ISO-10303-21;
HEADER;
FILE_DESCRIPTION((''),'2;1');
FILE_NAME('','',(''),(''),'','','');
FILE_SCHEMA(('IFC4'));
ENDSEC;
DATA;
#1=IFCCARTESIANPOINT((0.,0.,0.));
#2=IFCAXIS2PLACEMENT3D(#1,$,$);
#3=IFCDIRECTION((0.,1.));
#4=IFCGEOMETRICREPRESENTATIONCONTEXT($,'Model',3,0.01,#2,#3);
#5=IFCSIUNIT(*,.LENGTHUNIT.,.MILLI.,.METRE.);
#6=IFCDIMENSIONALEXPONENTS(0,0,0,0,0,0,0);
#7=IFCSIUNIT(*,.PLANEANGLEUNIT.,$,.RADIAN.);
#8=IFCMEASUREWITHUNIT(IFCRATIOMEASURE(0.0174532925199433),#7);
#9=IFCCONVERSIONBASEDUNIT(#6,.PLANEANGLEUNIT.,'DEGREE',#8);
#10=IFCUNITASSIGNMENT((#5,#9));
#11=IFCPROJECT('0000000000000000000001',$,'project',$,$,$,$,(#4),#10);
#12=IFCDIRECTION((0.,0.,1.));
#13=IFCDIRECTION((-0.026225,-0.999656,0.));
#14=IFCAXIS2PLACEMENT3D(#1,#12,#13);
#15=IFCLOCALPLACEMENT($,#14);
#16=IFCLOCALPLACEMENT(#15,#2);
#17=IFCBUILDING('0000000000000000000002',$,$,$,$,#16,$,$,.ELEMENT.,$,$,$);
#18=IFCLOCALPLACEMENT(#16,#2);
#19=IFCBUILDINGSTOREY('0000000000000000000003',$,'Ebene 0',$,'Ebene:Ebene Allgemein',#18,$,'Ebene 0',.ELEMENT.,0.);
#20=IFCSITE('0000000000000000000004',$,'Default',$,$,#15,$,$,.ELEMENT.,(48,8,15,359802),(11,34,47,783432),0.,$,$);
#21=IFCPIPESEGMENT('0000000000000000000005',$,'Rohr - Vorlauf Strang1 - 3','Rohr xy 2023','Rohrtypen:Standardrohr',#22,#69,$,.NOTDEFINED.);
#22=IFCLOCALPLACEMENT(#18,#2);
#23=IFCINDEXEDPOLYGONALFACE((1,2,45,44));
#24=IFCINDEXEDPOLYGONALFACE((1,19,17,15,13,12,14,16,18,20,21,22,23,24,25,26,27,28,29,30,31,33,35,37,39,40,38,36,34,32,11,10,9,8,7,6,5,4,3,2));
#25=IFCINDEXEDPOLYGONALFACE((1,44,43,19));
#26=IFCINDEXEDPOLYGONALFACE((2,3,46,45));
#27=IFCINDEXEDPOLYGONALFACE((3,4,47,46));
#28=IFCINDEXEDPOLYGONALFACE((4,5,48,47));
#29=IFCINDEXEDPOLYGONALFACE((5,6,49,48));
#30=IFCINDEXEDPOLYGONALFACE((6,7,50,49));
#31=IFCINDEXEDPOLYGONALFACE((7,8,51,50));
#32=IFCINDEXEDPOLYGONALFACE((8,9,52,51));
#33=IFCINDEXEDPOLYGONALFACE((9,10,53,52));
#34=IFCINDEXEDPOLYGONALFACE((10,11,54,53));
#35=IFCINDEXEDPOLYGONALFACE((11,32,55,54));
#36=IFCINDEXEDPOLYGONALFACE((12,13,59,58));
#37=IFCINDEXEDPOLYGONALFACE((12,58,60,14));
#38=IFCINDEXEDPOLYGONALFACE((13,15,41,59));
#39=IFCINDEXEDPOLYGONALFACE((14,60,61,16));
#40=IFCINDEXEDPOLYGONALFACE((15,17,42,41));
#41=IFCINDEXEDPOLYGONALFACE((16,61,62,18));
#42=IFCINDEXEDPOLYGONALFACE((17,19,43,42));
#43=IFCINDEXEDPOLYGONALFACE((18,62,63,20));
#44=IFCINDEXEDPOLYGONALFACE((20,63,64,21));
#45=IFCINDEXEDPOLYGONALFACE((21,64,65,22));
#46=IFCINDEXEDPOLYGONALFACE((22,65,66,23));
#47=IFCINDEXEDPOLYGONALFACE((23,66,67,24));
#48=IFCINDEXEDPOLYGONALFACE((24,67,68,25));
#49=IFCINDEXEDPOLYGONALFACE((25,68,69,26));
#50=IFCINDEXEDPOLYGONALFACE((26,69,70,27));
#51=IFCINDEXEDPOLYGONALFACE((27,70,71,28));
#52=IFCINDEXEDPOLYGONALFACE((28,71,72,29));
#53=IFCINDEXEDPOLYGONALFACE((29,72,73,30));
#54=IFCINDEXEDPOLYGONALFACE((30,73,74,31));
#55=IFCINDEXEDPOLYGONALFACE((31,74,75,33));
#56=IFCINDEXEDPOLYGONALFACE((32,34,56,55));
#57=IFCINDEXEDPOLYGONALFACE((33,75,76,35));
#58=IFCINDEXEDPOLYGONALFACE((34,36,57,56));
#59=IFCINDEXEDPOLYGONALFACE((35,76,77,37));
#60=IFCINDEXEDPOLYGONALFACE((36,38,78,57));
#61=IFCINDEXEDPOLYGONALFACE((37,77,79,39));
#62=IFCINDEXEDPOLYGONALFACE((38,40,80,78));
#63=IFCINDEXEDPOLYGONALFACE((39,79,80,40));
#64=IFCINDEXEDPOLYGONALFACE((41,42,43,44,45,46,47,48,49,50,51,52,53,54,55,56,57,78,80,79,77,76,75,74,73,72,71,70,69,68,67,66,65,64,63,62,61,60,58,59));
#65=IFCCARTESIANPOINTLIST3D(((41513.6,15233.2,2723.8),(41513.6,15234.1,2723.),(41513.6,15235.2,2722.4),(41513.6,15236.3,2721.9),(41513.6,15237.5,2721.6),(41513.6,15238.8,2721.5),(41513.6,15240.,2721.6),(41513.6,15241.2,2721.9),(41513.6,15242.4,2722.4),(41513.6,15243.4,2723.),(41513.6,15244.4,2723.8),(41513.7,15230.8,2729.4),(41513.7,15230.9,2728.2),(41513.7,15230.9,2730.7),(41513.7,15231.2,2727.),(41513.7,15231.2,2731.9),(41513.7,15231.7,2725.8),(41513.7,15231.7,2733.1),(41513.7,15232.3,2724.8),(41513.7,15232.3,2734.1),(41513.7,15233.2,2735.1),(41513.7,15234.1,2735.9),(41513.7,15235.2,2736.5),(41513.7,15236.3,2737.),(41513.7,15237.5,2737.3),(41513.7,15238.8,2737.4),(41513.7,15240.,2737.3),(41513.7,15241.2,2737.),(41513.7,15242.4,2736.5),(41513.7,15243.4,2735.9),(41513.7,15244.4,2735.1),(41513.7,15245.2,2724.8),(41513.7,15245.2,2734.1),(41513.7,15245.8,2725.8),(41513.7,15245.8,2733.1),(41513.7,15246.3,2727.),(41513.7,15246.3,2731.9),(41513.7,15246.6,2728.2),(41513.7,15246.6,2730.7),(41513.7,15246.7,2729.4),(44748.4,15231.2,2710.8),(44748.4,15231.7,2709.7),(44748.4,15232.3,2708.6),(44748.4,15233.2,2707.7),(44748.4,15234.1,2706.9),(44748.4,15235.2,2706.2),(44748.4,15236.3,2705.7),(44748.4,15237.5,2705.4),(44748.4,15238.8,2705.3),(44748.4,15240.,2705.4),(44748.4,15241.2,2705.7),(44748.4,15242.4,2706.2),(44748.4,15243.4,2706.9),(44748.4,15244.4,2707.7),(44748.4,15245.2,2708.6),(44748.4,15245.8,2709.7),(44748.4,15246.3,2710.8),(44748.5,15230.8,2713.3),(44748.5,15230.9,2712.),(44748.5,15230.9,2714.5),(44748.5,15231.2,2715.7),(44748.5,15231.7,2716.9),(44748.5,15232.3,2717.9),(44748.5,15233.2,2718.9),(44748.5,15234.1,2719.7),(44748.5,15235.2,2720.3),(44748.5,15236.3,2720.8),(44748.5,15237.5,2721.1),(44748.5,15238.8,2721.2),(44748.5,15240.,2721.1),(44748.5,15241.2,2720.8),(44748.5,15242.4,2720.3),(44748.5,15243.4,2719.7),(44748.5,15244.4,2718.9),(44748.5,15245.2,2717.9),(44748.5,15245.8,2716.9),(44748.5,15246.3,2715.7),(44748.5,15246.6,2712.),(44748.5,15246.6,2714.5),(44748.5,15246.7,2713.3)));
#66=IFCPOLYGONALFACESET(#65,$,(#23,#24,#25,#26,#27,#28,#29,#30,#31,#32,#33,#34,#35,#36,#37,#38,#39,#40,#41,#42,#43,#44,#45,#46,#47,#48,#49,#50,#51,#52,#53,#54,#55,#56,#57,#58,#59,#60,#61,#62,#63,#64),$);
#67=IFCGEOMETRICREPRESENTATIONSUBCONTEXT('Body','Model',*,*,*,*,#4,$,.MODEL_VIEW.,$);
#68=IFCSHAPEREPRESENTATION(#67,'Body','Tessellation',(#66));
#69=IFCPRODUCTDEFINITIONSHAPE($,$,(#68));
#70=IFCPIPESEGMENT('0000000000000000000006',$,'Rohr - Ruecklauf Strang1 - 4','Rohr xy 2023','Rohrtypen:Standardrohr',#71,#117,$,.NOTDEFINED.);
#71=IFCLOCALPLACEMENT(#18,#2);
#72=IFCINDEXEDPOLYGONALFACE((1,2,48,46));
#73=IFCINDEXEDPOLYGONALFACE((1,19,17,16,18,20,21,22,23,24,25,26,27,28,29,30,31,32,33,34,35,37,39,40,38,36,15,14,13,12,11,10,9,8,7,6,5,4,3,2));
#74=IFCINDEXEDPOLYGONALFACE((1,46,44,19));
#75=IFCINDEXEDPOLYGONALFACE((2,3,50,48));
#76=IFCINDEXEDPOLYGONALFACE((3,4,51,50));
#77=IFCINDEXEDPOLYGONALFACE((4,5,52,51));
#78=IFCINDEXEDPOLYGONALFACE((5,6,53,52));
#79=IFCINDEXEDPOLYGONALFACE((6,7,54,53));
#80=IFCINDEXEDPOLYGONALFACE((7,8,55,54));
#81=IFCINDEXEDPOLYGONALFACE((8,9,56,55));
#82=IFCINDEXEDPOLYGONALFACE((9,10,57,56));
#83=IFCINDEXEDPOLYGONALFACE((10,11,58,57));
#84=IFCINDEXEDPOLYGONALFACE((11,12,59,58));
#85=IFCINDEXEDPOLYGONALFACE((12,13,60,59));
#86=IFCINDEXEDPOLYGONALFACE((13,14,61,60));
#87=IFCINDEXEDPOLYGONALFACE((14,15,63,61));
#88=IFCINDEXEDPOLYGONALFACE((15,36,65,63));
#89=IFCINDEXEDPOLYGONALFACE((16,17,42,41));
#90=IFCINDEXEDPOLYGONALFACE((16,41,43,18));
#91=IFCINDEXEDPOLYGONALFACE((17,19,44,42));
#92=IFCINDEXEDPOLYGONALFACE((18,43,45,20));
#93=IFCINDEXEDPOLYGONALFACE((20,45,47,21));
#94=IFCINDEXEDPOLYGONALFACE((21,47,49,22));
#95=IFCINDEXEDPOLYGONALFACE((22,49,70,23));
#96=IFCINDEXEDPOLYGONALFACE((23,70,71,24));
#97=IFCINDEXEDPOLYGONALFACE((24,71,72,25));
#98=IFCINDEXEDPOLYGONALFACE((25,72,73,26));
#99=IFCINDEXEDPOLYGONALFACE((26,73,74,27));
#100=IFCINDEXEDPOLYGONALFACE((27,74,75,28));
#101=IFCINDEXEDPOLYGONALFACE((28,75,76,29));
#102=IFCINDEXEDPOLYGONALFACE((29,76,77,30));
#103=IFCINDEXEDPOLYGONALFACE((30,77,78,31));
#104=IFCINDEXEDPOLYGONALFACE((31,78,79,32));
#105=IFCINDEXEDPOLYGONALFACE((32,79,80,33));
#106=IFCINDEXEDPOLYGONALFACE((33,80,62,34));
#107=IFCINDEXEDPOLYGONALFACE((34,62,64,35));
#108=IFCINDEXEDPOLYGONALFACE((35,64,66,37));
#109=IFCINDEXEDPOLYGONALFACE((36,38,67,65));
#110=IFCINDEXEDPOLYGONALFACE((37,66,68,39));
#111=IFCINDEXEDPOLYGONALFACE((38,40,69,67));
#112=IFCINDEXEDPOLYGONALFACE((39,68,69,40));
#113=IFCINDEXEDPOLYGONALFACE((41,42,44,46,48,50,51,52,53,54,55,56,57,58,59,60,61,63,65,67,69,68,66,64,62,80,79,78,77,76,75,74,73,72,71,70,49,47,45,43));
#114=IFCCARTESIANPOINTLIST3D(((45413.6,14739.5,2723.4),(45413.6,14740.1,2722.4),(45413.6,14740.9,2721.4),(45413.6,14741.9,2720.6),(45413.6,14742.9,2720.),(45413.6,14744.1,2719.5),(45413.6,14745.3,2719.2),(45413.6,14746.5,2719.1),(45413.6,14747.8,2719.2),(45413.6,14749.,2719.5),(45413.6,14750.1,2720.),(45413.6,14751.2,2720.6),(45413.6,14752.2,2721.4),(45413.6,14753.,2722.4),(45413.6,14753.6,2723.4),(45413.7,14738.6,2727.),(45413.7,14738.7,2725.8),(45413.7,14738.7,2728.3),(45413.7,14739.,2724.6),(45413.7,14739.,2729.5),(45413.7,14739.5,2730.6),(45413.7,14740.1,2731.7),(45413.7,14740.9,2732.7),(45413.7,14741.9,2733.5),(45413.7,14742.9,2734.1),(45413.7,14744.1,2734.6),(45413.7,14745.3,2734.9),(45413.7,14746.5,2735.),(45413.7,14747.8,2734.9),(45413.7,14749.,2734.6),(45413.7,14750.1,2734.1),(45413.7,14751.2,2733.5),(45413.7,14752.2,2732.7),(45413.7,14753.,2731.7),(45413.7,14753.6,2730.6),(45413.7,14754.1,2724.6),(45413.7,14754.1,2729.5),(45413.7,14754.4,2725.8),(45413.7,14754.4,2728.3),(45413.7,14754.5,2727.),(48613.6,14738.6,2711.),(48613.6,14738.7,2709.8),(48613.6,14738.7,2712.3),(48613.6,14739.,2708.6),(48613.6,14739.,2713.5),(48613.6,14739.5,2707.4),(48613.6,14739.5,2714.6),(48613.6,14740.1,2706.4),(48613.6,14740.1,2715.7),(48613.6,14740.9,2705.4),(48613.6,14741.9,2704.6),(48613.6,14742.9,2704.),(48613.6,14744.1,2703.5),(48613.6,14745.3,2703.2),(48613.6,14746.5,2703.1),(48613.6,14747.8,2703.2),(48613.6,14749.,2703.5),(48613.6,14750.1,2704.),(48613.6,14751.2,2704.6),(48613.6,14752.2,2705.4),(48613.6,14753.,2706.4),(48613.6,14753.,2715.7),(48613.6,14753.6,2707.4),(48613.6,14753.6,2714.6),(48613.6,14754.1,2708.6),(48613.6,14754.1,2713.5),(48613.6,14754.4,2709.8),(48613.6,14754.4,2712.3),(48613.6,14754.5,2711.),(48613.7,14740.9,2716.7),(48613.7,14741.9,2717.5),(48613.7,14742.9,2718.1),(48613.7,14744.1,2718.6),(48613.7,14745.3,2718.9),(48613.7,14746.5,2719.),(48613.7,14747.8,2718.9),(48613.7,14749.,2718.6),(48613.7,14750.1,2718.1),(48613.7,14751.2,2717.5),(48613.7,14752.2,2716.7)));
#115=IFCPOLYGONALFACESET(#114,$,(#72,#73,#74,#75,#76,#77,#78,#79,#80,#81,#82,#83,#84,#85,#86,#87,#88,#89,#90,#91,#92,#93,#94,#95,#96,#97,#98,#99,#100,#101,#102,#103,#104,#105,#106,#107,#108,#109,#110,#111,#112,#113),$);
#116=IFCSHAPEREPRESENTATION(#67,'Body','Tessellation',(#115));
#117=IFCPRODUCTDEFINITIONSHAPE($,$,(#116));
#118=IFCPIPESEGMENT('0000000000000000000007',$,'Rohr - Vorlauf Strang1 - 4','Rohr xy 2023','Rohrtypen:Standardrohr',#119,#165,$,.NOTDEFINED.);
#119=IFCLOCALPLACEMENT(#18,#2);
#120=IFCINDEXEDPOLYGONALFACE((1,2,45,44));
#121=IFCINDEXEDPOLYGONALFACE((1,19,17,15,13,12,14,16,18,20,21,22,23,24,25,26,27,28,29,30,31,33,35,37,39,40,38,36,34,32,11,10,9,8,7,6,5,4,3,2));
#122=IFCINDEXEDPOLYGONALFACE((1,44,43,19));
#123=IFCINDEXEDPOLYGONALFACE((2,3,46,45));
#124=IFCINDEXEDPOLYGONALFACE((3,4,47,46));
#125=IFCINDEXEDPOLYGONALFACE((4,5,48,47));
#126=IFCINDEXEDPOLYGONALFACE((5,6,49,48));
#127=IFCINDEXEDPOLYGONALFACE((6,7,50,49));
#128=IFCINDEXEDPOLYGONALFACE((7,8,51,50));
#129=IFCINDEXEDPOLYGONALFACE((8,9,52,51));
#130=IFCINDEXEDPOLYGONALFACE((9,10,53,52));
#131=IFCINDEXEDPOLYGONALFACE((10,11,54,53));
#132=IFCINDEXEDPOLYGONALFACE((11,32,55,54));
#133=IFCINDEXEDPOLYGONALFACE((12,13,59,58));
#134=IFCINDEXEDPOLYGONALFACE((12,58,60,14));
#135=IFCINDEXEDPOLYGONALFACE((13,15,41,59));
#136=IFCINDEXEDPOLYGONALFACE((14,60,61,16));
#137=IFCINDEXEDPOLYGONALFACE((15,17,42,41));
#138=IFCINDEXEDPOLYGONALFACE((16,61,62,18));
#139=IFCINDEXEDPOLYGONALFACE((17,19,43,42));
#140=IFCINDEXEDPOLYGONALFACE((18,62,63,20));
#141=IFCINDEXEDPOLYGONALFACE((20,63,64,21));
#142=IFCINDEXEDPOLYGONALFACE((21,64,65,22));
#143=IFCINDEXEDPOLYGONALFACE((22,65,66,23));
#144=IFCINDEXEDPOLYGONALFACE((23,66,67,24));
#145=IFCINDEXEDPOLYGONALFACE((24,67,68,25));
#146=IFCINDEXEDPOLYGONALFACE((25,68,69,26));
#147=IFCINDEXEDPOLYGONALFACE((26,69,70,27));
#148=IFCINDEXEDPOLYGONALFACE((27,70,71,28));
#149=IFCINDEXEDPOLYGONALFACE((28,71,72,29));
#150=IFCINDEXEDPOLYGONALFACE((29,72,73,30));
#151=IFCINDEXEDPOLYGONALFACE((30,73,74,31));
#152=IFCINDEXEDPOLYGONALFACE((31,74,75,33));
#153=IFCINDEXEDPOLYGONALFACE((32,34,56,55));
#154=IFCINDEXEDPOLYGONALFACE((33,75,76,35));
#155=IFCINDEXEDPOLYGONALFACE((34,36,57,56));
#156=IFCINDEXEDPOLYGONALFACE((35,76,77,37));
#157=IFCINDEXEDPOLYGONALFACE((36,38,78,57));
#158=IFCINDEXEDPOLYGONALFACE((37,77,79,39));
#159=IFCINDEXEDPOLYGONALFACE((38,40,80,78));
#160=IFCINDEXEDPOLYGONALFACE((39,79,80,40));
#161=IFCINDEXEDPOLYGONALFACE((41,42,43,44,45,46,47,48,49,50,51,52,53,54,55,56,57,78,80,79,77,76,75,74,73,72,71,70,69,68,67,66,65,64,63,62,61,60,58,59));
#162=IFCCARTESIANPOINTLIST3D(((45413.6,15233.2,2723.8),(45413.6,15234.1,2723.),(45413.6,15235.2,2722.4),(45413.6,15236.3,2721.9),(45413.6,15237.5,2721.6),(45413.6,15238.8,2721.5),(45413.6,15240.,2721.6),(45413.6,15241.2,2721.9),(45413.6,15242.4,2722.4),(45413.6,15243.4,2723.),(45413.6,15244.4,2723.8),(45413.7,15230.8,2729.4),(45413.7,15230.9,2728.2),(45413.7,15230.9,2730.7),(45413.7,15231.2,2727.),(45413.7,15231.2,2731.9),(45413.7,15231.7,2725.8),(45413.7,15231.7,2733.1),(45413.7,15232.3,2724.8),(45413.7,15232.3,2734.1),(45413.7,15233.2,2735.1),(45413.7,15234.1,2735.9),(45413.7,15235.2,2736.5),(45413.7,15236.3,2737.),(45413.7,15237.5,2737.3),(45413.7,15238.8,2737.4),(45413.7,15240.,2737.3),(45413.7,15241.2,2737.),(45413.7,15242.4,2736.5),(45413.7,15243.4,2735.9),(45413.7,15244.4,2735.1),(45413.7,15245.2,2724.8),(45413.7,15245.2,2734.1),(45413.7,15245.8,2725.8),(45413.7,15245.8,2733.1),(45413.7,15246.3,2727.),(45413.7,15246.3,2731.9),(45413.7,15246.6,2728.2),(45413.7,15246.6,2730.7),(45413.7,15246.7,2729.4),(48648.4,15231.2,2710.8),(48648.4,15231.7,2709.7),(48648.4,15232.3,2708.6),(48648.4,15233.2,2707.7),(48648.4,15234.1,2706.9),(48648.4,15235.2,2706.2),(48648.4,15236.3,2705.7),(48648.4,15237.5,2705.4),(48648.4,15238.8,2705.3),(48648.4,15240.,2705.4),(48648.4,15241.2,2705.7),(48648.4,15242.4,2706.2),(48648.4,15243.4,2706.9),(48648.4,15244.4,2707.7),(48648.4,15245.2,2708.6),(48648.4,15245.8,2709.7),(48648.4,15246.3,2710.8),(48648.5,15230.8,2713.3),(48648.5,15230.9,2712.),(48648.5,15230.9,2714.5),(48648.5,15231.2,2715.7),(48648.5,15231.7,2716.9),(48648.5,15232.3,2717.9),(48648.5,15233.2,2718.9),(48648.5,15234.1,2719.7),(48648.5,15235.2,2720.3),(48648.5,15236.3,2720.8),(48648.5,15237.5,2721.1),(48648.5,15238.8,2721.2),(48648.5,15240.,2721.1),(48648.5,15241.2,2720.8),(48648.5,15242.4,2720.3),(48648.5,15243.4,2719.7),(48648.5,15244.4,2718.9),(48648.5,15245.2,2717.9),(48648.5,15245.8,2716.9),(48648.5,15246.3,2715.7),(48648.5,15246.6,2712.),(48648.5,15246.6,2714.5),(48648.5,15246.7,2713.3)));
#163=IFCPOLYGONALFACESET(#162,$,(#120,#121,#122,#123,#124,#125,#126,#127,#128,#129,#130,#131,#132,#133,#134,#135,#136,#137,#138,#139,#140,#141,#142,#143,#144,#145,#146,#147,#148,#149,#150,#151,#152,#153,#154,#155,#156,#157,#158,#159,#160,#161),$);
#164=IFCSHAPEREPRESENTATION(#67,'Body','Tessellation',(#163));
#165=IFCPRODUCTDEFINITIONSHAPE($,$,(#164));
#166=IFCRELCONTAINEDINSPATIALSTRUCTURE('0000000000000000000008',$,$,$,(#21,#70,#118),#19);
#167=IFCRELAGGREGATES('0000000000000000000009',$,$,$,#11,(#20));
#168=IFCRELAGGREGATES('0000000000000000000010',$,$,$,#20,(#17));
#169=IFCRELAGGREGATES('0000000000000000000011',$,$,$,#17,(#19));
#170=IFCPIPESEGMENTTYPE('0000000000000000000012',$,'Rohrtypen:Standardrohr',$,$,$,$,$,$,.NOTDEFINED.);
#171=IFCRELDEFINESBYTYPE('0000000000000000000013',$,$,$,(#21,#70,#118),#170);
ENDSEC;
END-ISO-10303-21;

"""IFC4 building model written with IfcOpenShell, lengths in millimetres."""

from ifc_helpers import new_model, entity, si_unit, converted_unit, direction, frame, origin, place, context, subcontext, project, spatial, indexed_curve, outline, extrude, type_object, element, save


model = new_model("IFC4")

# Units and contexts
model_context = context("Model", 3, precision=0.01, world=origin(), true_north=direction((0.0, 1.0)))
body_context = subcontext(model_context, "Body", "Model", "MODEL_VIEW")
ifc_project = project(units=[si_unit("LENGTHUNIT", "METRE", prefix="MILLI"), converted_unit("PLANEANGLEUNIT", "DEGREE", entity("IfcRatioMeasure", 0.0174532925199433), si_unit("PLANEANGLEUNIT", "RADIAN"), dimensions=[0, 0, 0, 0, 0, 0, 0])], contexts=[model_context])

# Site, building, storey
site_placement = place(None, frame((0.0, 0.0, 0.0), z_axis=(0.0, 0.0, 1.0), x_axis=(-0.026225, -0.999656, 0.0)))
site = spatial("IfcSite", under=ifc_project, at=site_placement, Name="Default", CompositionType="ELEMENT", RefLatitude=(48, 8, 15, 359802), RefLongitude=(11, 34, 47, 783432), RefElevation=0.0)
building_placement = place(site_placement, origin())
building = spatial("IfcBuilding", under=site, at=building_placement, CompositionType="ELEMENT")
storey_placement = place(building_placement, origin())
storey = spatial("IfcBuildingStorey", under=building, at=storey_placement, Name="Ebene 0", ObjectType="Ebene:Ebene Allgemein", LongName="Ebene 0", CompositionType="ELEMENT", Elevation=0.0)

# Pipe segments
pipe_segment_type = type_object("IfcPipeSegmentType", Name="Rohrtypen:Standardrohr", PredefinedType="NOTDEFINED")
pipe_segment_1_placement = place(storey_placement, origin())
element("IfcPipeSegment", 1, at=pipe_segment_1_placement, inside=storey, type_object=pipe_segment_type, Name="Rohr - Vorlauf Strang1 - 3", Description="Rohr xy 2023", ObjectType="Rohrtypen:Standardrohr", PredefinedType="NOTDEFINED", context=body_context, shape_type="SweptSolid", body=[
    extrude(outline(indexed_curve([(7.9, 0.0), (7.8, 1.2), (7.6, 2.5), (7.1, 3.6), (6.4, 4.7), (5.6, 5.6), (4.7, 6.4), (3.6, 7.1), (2.5, 7.6), (1.2, 7.8), (0.0, 7.9), (-1.2, 7.8), (-2.5, 7.6), (-3.6, 7.1), (-4.7, 6.4), (-5.6, 5.6), (-6.4, 4.7), (-7.1, 3.6), (-7.6, 2.5), (-7.8, 1.2), (-7.9, 0.0), (-7.8, -1.2), (-7.6, -2.5), (-7.1, -3.6), (-6.4, -4.7), (-5.6, -5.6), (-4.7, -6.4), (-3.6, -7.1), (-2.5, -7.6), (-1.2, -7.8), (0.0, -7.9), (1.2, -7.8), (2.5, -7.6), (3.6, -7.1), (4.7, -6.4), (5.6, -5.6), (6.4, -4.7), (7.1, -3.6), (7.6, -2.5), (7.8, -1.2), (7.9, 0.0)], self_intersect=False)), frame((44748.5, 15238.8, 2713.3), z_axis=(-0.999988, 0.0, 0.005), x_axis=(0.0, 1.0, 0.0)), (0.0, 0.0, 1.0), 3234.8),
])
pipe_segment_2_placement = place(storey_placement, origin())
element("IfcPipeSegment", 2, at=pipe_segment_2_placement, inside=storey, type_object=pipe_segment_type, Name="Rohr - Ruecklauf Strang1 - 4", Description="Rohr xy 2023", ObjectType="Rohrtypen:Standardrohr", PredefinedType="NOTDEFINED", context=body_context, shape_type="SweptSolid", body=[
    extrude(outline(indexed_curve([(7.9, 0.0), (7.8, 1.2), (7.6, 2.5), (7.1, 3.6), (6.4, 4.7), (5.6, 5.6), (4.7, 6.4), (3.6, 7.1), (2.5, 7.6), (1.2, 7.8), (0.0, 7.9), (-1.2, 7.8), (-2.5, 7.6), (-3.6, 7.1), (-4.7, 6.4), (-5.6, 5.6), (-6.4, 4.7), (-7.1, 3.6), (-7.6, 2.5), (-7.8, 1.2), (-7.9, 0.0), (-7.8, -1.2), (-7.6, -2.5), (-7.1, -3.6), (-6.4, -4.7), (-5.6, -5.6), (-4.7, -6.4), (-3.6, -7.1), (-2.5, -7.6), (-1.2, -7.8), (0.0, -7.9), (1.2, -7.8), (2.5, -7.6), (3.6, -7.1), (4.7, -6.4), (5.6, -5.6), (6.4, -4.7), (7.1, -3.6), (7.6, -2.5), (7.8, -1.2), (7.9, 0.0)], self_intersect=False)), frame((48613.6, 14746.5, 2711.0), z_axis=(-0.999988, 0.0, 0.005), x_axis=(0.0, 1.0, 0.0)), (0.0, 0.0, 1.0), 3200.0),
])
pipe_segment_3_placement = place(storey_placement, origin())
element("IfcPipeSegment", 3, at=pipe_segment_3_placement, inside=storey, type_object=pipe_segment_type, Name="Rohr - Vorlauf Strang1 - 4", Description="Rohr xy 2023", ObjectType="Rohrtypen:Standardrohr", PredefinedType="NOTDEFINED", context=body_context, shape_type="SweptSolid", body=[
    extrude(outline(indexed_curve([(7.9, 0.0), (7.8, 1.2), (7.6, 2.5), (7.1, 3.6), (6.4, 4.7), (5.6, 5.6), (4.7, 6.4), (3.6, 7.1), (2.5, 7.6), (1.2, 7.8), (0.0, 7.9), (-1.2, 7.8), (-2.5, 7.6), (-3.6, 7.1), (-4.7, 6.4), (-5.6, 5.6), (-6.4, 4.7), (-7.1, 3.6), (-7.6, 2.5), (-7.8, 1.2), (-7.9, 0.0), (-7.8, -1.2), (-7.6, -2.5), (-7.1, -3.6), (-6.4, -4.7), (-5.6, -5.6), (-4.7, -6.4), (-3.6, -7.1), (-2.5, -7.6), (-1.2, -7.8), (0.0, -7.9), (1.2, -7.8), (2.5, -7.6), (3.6, -7.1), (4.7, -6.4), (5.6, -5.6), (6.4, -4.7), (7.1, -3.6), (7.6, -2.5), (7.8, -1.2), (7.9, 0.0)], self_intersect=False)), frame((48648.5, 15238.8, 2713.3), z_axis=(-0.999988, 0.0, 0.005), x_axis=(0.0, 1.0, 0.0)), (0.0, 0.0, 1.0), 3234.8),
])

save(model, "model.ifc")
